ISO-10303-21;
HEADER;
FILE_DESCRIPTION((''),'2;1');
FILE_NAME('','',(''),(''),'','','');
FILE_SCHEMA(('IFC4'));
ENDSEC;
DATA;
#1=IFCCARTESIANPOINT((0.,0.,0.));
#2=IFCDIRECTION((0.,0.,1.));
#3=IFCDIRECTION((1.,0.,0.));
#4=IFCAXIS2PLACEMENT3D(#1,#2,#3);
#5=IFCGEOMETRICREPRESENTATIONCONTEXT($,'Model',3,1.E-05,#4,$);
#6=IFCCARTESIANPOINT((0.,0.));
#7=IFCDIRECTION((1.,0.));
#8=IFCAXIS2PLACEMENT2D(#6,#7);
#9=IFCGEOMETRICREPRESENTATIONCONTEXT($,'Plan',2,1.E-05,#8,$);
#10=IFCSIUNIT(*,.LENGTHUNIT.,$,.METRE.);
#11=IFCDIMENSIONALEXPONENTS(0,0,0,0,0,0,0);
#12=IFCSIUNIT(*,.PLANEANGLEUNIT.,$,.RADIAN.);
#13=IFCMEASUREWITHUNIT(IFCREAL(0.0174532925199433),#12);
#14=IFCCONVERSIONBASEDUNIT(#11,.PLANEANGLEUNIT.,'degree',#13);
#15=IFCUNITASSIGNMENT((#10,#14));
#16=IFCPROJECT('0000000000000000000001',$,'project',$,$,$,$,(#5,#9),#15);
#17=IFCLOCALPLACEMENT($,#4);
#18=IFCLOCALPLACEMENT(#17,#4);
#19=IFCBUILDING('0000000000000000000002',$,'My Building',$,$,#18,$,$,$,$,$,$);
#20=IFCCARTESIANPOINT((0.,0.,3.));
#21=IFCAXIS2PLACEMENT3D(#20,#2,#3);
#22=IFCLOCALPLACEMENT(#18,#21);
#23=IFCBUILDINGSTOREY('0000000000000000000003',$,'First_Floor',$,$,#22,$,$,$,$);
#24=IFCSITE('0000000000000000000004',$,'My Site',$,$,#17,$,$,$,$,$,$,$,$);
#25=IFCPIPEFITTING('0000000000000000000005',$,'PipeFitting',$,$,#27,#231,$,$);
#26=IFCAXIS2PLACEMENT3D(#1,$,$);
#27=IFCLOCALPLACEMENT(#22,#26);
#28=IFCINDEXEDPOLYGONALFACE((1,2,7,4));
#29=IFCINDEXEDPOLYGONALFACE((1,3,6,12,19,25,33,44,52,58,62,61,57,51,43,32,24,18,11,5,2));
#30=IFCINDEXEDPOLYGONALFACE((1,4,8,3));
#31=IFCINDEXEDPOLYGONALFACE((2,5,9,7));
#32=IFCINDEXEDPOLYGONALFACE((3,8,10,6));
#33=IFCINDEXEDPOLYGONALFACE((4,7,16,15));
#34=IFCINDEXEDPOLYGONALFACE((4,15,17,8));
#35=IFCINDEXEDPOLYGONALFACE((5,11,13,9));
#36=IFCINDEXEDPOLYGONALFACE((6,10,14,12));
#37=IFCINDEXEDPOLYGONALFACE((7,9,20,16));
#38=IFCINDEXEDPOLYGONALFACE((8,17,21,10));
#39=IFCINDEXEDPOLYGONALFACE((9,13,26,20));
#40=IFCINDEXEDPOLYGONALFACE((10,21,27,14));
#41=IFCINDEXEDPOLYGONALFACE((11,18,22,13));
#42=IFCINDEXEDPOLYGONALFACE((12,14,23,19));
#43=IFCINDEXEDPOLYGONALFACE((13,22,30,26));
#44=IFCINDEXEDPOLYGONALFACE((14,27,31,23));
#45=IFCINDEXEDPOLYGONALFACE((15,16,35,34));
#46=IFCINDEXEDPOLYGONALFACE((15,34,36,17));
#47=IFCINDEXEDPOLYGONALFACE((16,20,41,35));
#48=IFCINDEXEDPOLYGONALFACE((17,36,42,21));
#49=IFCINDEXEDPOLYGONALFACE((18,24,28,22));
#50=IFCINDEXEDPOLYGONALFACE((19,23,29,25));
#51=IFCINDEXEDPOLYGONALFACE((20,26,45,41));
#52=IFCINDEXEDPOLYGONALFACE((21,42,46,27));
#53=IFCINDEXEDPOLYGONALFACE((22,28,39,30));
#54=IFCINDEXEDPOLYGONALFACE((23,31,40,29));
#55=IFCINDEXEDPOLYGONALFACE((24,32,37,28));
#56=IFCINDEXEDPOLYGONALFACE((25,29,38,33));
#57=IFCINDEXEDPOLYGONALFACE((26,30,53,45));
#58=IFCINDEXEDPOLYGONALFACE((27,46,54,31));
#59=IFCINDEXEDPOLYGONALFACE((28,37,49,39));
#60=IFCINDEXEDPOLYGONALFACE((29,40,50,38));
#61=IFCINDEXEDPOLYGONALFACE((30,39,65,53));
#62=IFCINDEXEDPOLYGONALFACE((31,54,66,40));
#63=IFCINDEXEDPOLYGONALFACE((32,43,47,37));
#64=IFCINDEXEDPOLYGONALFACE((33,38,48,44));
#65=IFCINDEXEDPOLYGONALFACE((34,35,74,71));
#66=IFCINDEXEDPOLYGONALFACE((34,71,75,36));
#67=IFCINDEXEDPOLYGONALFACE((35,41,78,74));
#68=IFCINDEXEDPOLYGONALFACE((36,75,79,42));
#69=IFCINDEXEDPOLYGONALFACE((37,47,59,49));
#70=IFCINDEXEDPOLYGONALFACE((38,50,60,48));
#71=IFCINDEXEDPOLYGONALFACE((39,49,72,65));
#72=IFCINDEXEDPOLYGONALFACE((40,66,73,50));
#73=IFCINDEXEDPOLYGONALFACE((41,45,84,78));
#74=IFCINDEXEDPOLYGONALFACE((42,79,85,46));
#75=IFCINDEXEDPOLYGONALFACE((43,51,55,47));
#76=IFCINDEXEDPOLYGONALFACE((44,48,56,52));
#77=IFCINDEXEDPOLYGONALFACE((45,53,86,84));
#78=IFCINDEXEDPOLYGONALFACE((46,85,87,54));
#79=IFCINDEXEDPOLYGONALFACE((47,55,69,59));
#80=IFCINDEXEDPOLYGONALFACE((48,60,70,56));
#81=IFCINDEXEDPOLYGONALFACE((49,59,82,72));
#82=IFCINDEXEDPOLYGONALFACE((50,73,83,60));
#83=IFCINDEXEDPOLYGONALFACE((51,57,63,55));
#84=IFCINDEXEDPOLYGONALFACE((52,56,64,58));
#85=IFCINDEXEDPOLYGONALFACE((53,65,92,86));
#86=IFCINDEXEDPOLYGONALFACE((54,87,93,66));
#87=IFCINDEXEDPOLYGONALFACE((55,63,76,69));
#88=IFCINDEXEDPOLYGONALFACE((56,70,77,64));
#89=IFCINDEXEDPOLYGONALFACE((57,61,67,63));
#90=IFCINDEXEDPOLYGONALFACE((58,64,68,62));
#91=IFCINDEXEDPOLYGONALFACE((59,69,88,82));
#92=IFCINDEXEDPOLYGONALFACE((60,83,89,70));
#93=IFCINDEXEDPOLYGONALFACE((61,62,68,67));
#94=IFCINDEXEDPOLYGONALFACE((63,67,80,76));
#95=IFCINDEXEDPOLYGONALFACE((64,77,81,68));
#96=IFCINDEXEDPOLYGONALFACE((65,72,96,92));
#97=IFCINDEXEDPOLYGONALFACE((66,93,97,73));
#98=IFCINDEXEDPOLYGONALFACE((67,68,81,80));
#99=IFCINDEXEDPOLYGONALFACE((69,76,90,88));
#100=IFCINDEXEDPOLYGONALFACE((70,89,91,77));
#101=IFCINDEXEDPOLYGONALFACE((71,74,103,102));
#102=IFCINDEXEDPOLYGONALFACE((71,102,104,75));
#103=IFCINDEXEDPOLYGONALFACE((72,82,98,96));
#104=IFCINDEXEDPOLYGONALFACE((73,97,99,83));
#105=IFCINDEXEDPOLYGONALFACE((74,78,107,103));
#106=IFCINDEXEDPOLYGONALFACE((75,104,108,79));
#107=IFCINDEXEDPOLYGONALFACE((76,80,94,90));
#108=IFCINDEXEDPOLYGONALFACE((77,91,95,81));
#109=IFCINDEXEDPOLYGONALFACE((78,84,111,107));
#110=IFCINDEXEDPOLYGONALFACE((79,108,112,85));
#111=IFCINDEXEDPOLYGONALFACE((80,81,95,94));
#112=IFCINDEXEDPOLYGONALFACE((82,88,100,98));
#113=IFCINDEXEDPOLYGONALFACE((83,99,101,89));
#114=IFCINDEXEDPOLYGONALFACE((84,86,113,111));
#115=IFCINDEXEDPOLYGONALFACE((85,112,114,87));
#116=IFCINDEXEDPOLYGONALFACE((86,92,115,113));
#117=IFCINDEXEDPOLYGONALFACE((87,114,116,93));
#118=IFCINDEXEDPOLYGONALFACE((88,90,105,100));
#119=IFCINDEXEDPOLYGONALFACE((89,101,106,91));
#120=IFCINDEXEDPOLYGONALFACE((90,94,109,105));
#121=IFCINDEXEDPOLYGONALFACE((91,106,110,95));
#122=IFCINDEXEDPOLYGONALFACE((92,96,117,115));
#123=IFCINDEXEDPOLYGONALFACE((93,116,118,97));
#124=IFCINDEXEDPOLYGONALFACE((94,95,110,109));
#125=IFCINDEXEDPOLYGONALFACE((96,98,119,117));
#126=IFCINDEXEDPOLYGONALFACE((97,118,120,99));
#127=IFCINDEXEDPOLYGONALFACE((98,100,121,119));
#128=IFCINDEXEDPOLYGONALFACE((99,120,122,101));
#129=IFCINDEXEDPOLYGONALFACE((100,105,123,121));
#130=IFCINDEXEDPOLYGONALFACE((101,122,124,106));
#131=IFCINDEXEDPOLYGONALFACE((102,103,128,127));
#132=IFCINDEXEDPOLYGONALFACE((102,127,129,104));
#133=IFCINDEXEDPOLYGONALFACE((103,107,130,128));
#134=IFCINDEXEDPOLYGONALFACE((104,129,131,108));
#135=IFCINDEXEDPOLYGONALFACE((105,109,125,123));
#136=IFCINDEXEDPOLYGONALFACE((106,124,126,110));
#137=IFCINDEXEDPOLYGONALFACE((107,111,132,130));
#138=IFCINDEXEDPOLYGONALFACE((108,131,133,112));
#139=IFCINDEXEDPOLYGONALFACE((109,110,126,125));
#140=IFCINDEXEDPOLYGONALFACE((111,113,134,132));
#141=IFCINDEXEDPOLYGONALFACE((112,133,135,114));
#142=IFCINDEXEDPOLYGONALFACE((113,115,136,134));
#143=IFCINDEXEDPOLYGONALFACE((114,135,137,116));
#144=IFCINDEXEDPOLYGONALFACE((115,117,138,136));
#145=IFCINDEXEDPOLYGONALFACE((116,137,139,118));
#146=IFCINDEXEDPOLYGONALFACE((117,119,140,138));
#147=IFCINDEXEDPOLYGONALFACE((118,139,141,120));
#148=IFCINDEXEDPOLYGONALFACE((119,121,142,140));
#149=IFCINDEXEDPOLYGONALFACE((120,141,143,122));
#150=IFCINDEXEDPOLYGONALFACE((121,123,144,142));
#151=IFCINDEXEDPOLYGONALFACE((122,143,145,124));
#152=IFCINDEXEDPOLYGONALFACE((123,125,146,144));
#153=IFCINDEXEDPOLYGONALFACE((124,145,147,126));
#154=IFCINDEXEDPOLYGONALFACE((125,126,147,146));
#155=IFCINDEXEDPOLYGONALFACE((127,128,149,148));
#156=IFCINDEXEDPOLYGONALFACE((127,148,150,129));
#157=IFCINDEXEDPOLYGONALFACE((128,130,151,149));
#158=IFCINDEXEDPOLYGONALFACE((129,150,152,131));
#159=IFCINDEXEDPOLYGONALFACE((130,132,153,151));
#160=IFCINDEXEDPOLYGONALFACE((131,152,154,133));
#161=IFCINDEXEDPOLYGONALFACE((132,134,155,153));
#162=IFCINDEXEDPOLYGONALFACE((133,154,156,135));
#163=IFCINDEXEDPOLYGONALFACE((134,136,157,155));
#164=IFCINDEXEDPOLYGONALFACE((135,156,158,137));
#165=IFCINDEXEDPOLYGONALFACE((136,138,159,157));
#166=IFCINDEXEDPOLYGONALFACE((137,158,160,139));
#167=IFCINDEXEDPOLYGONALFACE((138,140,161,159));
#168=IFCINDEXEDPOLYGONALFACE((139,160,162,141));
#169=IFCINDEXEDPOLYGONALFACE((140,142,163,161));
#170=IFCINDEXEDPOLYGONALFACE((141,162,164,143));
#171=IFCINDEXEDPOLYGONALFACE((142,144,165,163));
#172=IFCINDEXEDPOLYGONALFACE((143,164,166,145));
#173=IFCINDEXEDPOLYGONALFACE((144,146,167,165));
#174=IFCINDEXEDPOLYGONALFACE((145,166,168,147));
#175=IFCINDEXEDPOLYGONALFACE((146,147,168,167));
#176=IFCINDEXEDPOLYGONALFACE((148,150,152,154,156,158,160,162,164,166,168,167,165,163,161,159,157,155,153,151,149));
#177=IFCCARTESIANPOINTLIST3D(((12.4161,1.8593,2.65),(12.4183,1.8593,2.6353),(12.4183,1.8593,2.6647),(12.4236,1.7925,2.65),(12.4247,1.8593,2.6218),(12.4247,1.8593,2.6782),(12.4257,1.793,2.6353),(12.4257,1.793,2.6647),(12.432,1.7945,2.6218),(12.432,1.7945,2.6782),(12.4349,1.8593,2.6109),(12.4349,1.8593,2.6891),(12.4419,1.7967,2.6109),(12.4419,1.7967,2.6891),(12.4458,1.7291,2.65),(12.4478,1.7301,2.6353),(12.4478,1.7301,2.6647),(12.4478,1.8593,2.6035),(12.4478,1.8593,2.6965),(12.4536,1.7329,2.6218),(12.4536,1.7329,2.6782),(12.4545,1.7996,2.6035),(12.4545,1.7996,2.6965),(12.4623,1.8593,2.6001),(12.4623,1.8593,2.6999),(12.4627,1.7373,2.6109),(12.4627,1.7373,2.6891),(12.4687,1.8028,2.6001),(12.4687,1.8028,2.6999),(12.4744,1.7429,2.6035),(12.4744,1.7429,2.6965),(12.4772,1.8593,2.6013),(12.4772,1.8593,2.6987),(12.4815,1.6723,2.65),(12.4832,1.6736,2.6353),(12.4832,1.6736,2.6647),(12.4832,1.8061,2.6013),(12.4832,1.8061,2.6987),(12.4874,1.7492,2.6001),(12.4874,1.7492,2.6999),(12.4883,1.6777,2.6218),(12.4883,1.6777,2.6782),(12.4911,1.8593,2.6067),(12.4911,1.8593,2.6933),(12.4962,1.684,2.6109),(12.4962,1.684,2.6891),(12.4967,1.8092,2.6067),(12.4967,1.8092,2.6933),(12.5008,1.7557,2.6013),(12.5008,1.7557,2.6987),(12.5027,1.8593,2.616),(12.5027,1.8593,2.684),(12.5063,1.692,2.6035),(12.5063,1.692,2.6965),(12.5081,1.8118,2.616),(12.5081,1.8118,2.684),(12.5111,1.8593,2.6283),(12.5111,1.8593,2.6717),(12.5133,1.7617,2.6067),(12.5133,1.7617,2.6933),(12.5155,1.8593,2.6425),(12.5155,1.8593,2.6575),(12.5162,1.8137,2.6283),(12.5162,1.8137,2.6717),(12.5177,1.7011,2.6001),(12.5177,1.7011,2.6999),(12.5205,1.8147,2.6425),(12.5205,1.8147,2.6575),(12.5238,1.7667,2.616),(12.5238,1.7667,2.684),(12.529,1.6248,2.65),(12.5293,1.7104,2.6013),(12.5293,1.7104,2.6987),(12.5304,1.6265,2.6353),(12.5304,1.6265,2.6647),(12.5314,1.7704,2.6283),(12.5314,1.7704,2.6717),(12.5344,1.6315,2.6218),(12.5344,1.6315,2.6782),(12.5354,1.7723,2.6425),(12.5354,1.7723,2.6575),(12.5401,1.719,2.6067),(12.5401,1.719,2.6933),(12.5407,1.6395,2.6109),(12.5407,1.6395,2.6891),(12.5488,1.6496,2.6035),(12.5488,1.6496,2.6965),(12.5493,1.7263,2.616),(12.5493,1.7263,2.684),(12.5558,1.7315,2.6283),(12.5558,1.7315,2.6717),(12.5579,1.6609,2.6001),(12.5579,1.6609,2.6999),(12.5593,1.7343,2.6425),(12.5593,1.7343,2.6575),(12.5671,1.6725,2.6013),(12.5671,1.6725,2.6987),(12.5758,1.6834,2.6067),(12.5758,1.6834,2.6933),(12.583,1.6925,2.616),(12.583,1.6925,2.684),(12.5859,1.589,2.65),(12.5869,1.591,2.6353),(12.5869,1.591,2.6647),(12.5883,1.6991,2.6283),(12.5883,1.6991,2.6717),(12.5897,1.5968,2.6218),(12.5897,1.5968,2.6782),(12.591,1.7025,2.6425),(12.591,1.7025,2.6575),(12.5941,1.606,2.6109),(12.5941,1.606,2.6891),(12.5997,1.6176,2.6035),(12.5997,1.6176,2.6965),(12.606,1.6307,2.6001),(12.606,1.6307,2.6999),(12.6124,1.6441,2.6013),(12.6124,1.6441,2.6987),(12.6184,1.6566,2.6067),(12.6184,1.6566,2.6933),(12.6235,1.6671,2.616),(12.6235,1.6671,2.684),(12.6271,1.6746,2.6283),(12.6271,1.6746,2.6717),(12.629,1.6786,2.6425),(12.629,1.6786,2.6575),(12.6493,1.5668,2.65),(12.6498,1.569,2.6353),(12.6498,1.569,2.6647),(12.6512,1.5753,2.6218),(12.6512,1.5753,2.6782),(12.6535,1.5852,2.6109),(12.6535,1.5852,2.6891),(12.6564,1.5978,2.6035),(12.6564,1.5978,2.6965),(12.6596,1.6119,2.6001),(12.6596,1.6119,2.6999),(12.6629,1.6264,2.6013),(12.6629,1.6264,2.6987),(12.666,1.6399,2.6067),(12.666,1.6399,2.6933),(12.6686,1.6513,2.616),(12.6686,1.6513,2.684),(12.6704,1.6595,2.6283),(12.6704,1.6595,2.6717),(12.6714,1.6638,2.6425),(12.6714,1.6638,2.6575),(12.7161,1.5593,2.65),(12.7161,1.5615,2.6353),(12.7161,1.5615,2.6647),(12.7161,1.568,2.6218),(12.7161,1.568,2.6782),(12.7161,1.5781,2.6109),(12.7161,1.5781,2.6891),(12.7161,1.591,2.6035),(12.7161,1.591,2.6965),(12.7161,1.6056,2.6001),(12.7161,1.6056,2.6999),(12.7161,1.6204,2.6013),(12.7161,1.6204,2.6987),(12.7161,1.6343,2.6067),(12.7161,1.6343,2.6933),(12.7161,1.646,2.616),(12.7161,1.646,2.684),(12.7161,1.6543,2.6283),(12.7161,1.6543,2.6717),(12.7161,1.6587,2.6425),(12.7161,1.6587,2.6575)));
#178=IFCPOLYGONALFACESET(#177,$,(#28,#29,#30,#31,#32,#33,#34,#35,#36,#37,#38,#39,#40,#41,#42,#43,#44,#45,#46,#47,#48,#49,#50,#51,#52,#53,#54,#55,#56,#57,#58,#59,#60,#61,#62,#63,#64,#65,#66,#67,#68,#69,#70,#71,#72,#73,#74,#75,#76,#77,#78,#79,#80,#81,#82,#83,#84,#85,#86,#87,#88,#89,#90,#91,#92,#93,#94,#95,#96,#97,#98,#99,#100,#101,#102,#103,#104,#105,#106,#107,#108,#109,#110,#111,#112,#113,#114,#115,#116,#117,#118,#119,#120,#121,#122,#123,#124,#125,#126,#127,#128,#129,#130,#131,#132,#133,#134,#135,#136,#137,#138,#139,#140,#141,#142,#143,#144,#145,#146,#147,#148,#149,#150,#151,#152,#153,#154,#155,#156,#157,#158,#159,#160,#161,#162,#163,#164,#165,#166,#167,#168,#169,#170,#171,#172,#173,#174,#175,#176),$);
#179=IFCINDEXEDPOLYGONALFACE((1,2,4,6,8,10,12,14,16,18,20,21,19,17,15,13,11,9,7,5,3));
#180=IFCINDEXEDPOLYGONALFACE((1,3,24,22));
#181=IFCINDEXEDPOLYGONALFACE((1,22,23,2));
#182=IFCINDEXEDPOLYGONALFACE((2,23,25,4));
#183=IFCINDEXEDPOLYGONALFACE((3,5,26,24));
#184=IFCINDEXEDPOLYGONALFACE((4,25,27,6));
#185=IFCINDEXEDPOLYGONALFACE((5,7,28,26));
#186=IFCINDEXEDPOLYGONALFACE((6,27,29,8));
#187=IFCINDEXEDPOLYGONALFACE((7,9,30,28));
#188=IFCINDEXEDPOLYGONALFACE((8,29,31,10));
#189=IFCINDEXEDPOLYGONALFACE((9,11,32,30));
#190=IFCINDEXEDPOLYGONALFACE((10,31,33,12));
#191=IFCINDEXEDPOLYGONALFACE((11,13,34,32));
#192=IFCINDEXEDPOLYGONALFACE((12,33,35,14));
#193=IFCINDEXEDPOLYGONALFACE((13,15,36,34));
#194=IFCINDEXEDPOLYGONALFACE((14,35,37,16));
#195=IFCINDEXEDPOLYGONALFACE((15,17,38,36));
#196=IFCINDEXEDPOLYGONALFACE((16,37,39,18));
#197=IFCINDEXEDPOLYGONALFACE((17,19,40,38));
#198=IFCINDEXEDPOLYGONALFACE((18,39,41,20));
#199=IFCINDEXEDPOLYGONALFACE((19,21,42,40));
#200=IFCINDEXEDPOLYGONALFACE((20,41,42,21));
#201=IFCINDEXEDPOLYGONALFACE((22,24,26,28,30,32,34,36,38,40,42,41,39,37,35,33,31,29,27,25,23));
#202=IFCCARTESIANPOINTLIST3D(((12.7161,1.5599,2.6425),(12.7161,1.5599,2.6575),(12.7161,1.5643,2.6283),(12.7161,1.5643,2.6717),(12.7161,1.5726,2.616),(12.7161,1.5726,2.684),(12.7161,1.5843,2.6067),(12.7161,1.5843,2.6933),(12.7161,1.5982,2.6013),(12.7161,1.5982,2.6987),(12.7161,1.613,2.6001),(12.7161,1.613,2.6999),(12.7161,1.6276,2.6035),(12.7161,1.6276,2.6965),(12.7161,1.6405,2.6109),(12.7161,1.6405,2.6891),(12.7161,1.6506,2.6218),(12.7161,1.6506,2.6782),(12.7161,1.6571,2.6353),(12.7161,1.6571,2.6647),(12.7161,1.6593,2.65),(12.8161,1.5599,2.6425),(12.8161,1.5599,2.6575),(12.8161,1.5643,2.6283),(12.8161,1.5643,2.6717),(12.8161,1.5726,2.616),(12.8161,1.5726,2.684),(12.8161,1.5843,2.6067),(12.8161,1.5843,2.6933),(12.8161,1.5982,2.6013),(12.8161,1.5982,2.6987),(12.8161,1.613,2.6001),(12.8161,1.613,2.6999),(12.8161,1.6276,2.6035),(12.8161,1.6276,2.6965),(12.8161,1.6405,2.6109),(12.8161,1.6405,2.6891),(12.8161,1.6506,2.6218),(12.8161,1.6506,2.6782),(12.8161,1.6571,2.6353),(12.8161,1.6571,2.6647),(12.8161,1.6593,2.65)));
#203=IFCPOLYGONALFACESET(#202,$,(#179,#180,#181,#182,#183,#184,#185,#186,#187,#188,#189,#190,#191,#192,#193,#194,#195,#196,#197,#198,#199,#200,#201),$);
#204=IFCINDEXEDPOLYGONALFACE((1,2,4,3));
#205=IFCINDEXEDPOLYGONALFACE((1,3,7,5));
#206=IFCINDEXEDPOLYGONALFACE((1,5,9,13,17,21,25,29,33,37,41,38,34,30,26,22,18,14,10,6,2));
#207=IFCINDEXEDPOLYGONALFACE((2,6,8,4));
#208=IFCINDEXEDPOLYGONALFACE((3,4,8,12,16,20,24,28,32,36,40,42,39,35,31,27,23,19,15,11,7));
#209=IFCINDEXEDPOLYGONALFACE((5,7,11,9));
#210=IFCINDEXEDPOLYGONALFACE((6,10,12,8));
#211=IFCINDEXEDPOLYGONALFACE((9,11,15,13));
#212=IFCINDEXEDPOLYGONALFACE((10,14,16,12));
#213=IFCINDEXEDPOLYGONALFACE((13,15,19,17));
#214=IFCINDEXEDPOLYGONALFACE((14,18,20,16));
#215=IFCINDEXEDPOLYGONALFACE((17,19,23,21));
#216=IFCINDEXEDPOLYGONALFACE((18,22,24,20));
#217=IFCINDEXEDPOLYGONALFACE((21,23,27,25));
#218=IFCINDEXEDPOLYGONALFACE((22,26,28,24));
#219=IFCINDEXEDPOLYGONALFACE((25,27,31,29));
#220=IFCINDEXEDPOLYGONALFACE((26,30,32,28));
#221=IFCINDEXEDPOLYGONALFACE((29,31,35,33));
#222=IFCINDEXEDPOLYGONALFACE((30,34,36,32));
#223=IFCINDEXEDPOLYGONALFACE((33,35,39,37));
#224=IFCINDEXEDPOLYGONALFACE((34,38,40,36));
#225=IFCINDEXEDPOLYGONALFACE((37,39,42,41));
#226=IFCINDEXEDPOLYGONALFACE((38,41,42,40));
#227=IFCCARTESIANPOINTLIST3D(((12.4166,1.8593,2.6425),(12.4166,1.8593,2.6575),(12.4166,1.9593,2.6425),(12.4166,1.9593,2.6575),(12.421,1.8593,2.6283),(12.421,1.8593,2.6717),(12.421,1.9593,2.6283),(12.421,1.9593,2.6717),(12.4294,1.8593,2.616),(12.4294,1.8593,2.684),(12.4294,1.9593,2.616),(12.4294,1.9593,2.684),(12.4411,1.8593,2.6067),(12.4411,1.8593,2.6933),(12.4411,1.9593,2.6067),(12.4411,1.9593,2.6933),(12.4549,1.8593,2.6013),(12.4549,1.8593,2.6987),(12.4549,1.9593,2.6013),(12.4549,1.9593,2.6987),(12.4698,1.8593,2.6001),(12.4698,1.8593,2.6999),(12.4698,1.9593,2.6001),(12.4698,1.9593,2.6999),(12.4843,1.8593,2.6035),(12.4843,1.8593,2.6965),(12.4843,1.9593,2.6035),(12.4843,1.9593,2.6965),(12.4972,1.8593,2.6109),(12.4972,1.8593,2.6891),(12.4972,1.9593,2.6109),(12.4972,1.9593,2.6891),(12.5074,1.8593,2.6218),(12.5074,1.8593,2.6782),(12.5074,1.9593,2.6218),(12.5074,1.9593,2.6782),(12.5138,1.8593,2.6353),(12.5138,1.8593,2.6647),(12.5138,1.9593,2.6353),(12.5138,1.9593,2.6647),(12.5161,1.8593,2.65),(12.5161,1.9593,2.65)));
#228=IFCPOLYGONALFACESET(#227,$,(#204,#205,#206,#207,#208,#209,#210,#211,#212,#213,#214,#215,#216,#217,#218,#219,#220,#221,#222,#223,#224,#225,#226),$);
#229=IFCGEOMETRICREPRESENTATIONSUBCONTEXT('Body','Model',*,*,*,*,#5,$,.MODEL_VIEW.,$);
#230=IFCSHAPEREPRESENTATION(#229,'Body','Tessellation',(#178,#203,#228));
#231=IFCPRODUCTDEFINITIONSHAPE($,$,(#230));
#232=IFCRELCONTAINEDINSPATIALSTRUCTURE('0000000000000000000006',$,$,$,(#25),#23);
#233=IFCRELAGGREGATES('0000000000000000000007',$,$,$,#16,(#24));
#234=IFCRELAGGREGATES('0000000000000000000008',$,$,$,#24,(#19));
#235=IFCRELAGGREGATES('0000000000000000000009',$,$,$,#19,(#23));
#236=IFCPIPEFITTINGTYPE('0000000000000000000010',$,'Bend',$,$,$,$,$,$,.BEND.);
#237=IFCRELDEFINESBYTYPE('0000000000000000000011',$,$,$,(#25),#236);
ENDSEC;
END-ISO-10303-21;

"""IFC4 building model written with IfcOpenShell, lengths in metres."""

from ifc_helpers import new_model, entity, si_unit, converted_unit, frame, origin_with_axes, origin_2d_with_axis, place, context, subcontext, project, spatial, circle, extrude, source, transform, mapped, type_object, type_shapes, element, save


model = new_model("IFC4")

# Units and contexts
model_context = context("Model", 3, precision=1e-05, world=origin_with_axes())
plan_context = context("Plan", 2, precision=1e-05, world=origin_2d_with_axis())
body_context = subcontext(model_context, "Body", "Model", "MODEL_VIEW")
ifc_project = project(units=[si_unit("LENGTHUNIT", "METRE"), converted_unit("PLANEANGLEUNIT", "degree", entity("IfcReal", 0.0174532925199433), si_unit("PLANEANGLEUNIT", "RADIAN"), dimensions=[0, 0, 0, 0, 0, 0, 0])], contexts=[model_context, plan_context])

# Site, building, storey
site_placement = place(None, origin_with_axes())
site = spatial("IfcSite", under=ifc_project, at=site_placement, Name="My Site")
building_placement = place(site_placement, origin_with_axes())
building = spatial("IfcBuilding", under=site, at=building_placement, Name="My Building")
storey_placement = place(building_placement, frame((0.0, 0.0, 3.0), z_axis=(0.0, 0.0, 1.0), x_axis=(1.0, 0.0, 0.0)))
storey = spatial("IfcBuildingStorey", under=building, at=storey_placement, Name="First_Floor")

# Pipe fitting
pipe_fitting_type = type_object("IfcPipeFittingType", Name="Bend", PredefinedType="BEND")
shared_shape_1 = source(origin_with_axes(), body_context, "Body", "SolidModel", [
    entity("IfcSweptDiskSolid", entity("IfcIndexedPolyCurve", entity("IfcCartesianPointList3D", [[0.0, 0.0, -0.1], [0.0732, 0.0, -0.2768], [0.25, 0.0, -0.35]]), [entity("IfcArcIndex", [1, 2, 3])]), 0.05),
    extrude(circle(Radius=0.05), origin_with_axes(), (0.0, 0.0, -1.0), 0.1),
    extrude(circle(Radius=0.05), frame((0.25, 0.0, -0.35), z_axis=(1.0, 0.0, 0.0), x_axis=(0.0, 0.0, 1.0)), (0.0, 0.0, 1.0), 0.1),
])
type_shapes(pipe_fitting_type, [shared_shape_1])
for number, where, z_axis, x_axis, name in (
    (1, (12.8161, 1.6093, 2.65), (1.0, 0.0, 0.0), (0.0, 1.0, 0.0), "PipeFitting"),
):
    element("IfcPipeFitting", number, at=place(storey_placement, frame(where, z_axis=z_axis, x_axis=x_axis)), inside=storey, type_object=pipe_fitting_type, Name=name, context=body_context, shape_type="MappedRepresentation", body=[
        mapped(shared_shape_1, transform((0.0, 0.0, 0.0), x_axis=(1.0, 0.0, 0.0), y_axis=(0.0, 1.0, 0.0), z_axis=(0.0, 0.0, 1.0), scale=1.0)),
    ])

save(model, "model.ifc")
